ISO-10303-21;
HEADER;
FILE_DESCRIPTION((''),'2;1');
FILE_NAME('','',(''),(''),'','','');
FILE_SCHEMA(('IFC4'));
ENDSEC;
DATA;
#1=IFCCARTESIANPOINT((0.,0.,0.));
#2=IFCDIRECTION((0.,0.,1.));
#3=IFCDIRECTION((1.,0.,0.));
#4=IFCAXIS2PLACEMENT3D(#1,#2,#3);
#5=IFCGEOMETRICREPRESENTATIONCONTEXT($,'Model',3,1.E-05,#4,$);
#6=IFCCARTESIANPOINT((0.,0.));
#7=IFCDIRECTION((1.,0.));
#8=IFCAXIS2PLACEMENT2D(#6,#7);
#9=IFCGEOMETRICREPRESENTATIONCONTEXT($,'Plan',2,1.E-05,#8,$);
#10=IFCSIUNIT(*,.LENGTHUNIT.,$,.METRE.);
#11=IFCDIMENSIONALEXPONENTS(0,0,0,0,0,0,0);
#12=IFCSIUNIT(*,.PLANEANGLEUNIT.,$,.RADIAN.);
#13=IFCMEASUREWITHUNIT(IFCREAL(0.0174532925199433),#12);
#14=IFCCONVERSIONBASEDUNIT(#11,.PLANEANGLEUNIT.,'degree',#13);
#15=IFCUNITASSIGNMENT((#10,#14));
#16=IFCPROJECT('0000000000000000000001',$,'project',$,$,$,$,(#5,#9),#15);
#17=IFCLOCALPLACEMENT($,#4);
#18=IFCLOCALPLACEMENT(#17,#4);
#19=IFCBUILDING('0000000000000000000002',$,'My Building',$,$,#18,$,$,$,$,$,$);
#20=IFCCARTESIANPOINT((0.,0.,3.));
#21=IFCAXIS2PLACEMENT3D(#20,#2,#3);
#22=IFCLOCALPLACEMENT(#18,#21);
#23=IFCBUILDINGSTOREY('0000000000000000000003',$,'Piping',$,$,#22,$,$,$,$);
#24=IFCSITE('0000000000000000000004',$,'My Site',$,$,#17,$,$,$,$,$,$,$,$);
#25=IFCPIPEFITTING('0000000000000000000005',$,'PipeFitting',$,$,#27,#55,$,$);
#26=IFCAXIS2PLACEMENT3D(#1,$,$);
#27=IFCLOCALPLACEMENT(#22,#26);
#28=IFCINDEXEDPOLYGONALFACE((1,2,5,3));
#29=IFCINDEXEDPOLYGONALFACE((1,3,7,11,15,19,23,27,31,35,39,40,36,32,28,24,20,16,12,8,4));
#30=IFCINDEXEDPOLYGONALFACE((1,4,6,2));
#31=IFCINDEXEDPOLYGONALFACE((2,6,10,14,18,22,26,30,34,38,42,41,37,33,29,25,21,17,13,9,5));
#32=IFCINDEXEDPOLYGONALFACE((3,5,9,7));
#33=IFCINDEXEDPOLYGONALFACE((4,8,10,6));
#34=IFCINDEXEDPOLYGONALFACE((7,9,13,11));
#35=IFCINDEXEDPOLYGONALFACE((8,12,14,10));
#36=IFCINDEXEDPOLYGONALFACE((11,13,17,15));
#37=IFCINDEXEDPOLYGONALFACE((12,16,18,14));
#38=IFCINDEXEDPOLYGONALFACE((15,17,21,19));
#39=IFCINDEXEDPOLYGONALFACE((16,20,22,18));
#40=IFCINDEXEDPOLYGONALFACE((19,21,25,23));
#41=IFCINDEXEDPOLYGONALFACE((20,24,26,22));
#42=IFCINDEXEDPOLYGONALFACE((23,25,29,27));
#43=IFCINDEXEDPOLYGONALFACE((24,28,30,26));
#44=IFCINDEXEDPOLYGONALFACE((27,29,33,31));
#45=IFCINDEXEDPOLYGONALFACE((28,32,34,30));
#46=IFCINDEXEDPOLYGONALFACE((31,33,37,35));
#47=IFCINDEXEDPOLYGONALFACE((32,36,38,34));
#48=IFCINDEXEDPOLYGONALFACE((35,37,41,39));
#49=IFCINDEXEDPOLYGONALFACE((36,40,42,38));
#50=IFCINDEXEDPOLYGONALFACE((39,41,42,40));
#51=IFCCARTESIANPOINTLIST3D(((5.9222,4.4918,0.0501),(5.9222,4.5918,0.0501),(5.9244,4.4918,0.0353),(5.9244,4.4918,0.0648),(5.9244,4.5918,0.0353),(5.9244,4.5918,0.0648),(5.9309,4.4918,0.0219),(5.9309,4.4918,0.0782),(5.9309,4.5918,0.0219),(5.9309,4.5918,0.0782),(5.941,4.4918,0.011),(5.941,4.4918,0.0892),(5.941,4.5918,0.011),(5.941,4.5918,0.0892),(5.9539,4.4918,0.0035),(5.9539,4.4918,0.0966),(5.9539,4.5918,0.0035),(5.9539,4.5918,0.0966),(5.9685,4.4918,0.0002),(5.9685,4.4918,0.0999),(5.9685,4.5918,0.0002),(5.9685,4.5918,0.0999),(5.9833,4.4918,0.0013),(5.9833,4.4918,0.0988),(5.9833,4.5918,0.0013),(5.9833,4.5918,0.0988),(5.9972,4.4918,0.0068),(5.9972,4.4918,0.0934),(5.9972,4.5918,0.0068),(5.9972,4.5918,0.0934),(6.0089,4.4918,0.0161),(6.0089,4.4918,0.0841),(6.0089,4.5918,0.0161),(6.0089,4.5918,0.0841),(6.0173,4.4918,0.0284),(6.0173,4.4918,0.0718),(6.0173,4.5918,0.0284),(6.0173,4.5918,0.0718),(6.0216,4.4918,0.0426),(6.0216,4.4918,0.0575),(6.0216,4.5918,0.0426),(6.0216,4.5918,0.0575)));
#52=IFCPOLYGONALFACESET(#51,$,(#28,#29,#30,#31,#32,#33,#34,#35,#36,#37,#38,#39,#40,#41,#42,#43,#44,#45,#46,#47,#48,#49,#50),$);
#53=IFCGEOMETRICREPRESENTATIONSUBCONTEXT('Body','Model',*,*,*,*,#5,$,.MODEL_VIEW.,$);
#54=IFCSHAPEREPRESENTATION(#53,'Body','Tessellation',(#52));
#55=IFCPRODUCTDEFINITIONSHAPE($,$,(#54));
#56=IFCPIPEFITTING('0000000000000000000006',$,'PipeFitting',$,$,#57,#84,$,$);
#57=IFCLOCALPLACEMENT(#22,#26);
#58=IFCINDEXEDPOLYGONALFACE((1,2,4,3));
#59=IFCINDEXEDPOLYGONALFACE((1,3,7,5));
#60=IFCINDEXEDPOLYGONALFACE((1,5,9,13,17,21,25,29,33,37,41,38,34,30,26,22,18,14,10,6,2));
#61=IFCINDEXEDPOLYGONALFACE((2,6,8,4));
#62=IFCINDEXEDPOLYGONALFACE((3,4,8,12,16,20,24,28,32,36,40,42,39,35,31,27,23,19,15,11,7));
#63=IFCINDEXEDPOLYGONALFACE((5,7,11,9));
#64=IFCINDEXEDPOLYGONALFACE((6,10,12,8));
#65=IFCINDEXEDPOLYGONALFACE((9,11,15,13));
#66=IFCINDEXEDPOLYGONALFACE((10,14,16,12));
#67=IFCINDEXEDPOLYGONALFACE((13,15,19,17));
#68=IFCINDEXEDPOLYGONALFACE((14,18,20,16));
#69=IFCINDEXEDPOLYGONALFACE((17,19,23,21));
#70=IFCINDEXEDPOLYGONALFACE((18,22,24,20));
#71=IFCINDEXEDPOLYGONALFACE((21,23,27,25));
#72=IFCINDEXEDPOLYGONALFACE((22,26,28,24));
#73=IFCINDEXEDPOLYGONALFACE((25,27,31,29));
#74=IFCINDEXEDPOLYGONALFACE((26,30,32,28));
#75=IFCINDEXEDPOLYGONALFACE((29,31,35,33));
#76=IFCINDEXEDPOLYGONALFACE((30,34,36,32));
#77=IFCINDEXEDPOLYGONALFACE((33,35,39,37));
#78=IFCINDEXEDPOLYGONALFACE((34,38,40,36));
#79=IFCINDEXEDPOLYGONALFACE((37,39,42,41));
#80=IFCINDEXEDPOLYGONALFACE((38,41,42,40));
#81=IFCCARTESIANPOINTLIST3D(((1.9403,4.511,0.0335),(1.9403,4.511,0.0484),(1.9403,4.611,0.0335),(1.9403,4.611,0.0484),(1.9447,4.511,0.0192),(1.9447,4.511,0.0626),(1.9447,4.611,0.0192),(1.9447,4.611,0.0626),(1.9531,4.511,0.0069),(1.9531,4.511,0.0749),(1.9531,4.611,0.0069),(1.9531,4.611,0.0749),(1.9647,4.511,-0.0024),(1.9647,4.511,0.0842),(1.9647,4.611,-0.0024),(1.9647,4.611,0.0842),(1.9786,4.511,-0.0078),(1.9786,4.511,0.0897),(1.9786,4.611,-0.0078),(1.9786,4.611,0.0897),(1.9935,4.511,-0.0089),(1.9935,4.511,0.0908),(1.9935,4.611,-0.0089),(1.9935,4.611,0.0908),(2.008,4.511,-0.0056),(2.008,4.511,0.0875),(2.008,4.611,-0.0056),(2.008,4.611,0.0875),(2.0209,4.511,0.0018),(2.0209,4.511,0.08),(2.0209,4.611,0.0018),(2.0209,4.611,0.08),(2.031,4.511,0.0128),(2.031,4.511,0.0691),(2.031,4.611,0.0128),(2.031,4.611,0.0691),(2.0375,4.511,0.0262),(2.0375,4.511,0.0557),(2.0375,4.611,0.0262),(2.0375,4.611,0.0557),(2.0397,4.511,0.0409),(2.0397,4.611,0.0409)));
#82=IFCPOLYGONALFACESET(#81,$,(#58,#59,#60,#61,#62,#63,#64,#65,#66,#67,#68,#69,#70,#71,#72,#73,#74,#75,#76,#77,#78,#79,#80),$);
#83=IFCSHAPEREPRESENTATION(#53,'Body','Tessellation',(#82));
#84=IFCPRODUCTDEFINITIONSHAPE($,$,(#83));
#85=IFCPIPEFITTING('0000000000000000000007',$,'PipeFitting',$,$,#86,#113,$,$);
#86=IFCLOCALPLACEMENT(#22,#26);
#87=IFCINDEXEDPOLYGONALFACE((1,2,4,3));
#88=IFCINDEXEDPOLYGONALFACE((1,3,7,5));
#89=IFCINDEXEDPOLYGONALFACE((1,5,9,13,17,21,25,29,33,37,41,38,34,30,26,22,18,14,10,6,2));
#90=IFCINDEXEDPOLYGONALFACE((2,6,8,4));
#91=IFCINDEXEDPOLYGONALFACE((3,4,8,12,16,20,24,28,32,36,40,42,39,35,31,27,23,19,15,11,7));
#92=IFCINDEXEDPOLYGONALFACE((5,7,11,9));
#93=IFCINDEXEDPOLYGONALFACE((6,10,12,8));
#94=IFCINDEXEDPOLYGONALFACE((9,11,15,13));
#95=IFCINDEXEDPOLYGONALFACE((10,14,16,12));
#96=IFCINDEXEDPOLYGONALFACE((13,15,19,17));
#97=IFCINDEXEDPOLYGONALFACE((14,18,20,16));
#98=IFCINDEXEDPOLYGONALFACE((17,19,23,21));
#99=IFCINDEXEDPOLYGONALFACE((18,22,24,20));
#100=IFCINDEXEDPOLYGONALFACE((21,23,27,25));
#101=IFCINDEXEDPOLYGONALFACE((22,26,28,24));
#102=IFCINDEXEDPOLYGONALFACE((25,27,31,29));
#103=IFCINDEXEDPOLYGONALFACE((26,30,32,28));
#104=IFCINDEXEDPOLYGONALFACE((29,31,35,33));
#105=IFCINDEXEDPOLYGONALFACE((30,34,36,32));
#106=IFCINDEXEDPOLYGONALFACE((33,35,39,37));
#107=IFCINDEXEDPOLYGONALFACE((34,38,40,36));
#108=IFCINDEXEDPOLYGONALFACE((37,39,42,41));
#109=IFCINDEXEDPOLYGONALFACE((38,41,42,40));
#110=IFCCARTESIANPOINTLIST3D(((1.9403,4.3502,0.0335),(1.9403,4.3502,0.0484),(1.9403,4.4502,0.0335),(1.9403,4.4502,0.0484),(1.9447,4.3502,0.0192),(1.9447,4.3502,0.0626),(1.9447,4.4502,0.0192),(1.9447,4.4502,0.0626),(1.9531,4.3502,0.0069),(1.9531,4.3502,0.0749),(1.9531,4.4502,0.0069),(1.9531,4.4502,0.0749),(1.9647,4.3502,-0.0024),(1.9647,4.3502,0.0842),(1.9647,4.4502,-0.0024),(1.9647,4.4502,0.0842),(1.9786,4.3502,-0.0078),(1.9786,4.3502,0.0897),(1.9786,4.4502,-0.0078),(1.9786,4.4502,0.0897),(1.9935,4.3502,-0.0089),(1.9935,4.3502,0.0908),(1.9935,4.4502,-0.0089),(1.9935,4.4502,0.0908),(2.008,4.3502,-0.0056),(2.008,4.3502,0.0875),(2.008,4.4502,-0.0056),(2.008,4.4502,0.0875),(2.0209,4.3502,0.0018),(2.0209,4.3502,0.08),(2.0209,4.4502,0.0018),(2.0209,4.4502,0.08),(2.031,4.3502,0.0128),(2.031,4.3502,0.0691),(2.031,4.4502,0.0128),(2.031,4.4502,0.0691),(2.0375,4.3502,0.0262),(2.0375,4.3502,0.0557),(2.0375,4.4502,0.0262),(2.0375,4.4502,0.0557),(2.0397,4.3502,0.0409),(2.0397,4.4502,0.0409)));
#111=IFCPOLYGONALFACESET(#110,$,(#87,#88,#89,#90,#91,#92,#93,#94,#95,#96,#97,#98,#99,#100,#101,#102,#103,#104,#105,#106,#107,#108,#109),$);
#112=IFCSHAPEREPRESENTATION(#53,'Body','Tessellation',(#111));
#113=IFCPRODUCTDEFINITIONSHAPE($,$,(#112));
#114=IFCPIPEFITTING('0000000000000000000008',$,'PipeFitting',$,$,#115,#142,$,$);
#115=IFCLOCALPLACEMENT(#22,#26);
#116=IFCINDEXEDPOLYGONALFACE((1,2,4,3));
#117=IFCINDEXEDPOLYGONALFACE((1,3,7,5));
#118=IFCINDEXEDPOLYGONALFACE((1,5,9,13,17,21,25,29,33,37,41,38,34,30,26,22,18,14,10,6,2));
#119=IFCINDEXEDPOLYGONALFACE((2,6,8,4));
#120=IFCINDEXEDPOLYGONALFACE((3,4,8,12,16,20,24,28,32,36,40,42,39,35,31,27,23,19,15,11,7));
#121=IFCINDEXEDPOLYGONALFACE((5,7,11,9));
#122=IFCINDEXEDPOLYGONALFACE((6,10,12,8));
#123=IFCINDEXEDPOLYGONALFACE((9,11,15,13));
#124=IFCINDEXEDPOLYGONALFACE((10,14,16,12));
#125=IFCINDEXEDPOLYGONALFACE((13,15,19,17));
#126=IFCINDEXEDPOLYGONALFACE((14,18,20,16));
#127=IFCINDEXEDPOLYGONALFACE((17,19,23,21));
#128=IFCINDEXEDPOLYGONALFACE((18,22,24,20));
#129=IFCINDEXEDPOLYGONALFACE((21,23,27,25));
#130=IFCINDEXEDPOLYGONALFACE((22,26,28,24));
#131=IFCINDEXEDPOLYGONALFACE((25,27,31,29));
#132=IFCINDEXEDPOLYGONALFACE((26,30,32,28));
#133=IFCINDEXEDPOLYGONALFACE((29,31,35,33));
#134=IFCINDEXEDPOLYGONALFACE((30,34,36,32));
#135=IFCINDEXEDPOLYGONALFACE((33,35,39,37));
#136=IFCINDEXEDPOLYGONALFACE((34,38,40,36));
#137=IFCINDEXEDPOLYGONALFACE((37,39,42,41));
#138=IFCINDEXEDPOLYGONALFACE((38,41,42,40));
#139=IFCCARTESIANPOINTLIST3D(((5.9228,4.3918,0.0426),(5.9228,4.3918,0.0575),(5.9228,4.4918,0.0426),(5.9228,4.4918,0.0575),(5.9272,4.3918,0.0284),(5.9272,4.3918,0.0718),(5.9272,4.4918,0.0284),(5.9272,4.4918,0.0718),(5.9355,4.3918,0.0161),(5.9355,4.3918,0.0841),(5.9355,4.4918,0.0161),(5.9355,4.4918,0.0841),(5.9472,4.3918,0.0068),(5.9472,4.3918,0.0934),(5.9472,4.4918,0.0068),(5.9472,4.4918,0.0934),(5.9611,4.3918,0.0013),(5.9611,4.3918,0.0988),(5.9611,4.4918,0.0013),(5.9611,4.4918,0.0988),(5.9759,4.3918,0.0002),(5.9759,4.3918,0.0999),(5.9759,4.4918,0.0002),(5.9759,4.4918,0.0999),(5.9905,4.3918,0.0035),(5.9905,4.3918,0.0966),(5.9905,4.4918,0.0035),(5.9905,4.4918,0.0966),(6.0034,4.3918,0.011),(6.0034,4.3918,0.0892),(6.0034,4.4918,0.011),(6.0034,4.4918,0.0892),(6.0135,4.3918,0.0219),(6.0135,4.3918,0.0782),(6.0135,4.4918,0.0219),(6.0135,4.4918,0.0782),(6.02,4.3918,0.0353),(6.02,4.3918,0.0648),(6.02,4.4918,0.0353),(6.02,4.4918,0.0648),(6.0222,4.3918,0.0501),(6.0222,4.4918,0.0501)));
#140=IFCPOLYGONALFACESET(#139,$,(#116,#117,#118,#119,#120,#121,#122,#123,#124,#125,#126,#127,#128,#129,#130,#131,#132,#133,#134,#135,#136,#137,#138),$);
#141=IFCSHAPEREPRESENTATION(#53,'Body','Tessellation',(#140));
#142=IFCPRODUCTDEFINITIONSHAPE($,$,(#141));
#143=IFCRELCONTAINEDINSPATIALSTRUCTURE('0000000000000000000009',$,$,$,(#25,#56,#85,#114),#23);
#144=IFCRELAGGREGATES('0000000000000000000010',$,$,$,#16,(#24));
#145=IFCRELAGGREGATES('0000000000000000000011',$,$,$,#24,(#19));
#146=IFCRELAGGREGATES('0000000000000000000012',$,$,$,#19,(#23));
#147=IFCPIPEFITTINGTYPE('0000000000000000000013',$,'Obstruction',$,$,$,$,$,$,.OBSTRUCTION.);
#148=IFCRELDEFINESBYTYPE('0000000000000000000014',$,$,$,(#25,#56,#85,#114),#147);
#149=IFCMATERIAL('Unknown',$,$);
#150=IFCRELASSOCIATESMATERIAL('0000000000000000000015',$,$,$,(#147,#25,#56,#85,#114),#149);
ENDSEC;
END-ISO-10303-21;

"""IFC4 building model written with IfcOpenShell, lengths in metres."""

from ifc_helpers import new_model, entity, si_unit, converted_unit, frame, origin_with_axes, origin_2d_with_axis, place, context, subcontext, project, spatial, circle, extrude, material, material_profile, profile_set, profile_usage, type_object, element, save


model = new_model("IFC4")

# Units and contexts
model_context = context("Model", 3, precision=1e-05, world=origin_with_axes())
plan_context = context("Plan", 2, precision=1e-05, world=origin_2d_with_axis())
body_context = subcontext(model_context, "Body", "Model", "MODEL_VIEW")
ifc_project = project(units=[si_unit("LENGTHUNIT", "METRE"), converted_unit("PLANEANGLEUNIT", "degree", entity("IfcReal", 0.0174532925199433), si_unit("PLANEANGLEUNIT", "RADIAN"), dimensions=[0, 0, 0, 0, 0, 0, 0])], contexts=[model_context, plan_context])

# Site, building, storey
site_placement = place(None, origin_with_axes())
site = spatial("IfcSite", under=ifc_project, at=site_placement, Name="My Site")
building_placement = place(site_placement, origin_with_axes())
building = spatial("IfcBuilding", under=site, at=building_placement, Name="My Building")
storey_placement = place(building_placement, frame((0.0, 0.0, 3.0), z_axis=(0.0, 0.0, 1.0), x_axis=(1.0, 0.0, 0.0)))
storey = spatial("IfcBuildingStorey", under=building, at=storey_placement, Name="Piping")

# Shared definitions
ifc_material = material(Name="Unknown")

# Pipe fittings
ifc_material_profile_1 = material_profile(ifc_material, circle(Radius=0.05))
ifc_profile_set_1 = profile_set([ifc_material_profile_1])
ifc_profile_usage_1 = profile_usage(ifc_profile_set_1, cardinal=15)
pipe_fitting_type_1 = type_object("IfcPipeFittingType", Name="Obstruction", PredefinedType="OBSTRUCTION", material=ifc_profile_set_1)
pipe_fitting_1_placement = place(storey_placement, frame((5.9722, 4.4918, 0.0501), z_axis=(0.0, 1.0, 0.0), x_axis=(-1.0, 0.0, 0.0)))
element("IfcPipeFitting", 1, at=pipe_fitting_1_placement, inside=storey, type_object=pipe_fitting_type_1, material=ifc_profile_usage_1, Name="PipeFitting", context=body_context, shape_type="SweptSolid", body=[
    extrude(circle(Radius=0.05), origin_with_axes(), (0.0, 0.0, 1.0), 0.1),
])
ifc_profile_usage_2 = profile_usage(ifc_profile_set_1, cardinal=15)
pipe_fitting_2_placement = place(storey_placement, frame((1.9897, 4.611, 0.0409), z_axis=(0.0, -1.0, 0.000005), x_axis=(1.0, 0.0, 0.0)))
element("IfcPipeFitting", 2, at=pipe_fitting_2_placement, inside=storey, type_object=pipe_fitting_type_1, material=ifc_profile_usage_2, Name="PipeFitting", context=body_context, shape_type="SweptSolid", body=[
    extrude(circle(Radius=0.05), origin_with_axes(), (0.0, 0.0, 1.0), 0.1),
])
ifc_profile_usage_3 = profile_usage(ifc_profile_set_1, cardinal=15)
pipe_fitting_3_placement = place(storey_placement, frame((1.9897, 4.3502, 0.0409), z_axis=(0.0, 1.0, 0.000005), x_axis=(1.0, 0.0, -0.000001)))
element("IfcPipeFitting", 3, at=pipe_fitting_3_placement, inside=storey, type_object=pipe_fitting_type_1, material=ifc_profile_usage_3, Name="PipeFitting", context=body_context, shape_type="SweptSolid", body=[
    extrude(circle(Radius=0.05), origin_with_axes(), (0.0, 0.0, 1.0), 0.1),
])
ifc_profile_usage_4 = profile_usage(ifc_profile_set_1, cardinal=15)
pipe_fitting_4_placement = place(storey_placement, frame((5.9722, 4.4918, 0.0501), z_axis=(0.0, -1.0, 0.0), x_axis=(1.0, 0.0, 0.0)))
element("IfcPipeFitting", 4, at=pipe_fitting_4_placement, inside=storey, type_object=pipe_fitting_type_1, material=ifc_profile_usage_4, Name="PipeFitting", context=body_context, shape_type="SweptSolid", body=[
    extrude(circle(Radius=0.05), origin_with_axes(), (0.0, 0.0, 1.0), 0.1),
])

save(model, "model.ifc")
